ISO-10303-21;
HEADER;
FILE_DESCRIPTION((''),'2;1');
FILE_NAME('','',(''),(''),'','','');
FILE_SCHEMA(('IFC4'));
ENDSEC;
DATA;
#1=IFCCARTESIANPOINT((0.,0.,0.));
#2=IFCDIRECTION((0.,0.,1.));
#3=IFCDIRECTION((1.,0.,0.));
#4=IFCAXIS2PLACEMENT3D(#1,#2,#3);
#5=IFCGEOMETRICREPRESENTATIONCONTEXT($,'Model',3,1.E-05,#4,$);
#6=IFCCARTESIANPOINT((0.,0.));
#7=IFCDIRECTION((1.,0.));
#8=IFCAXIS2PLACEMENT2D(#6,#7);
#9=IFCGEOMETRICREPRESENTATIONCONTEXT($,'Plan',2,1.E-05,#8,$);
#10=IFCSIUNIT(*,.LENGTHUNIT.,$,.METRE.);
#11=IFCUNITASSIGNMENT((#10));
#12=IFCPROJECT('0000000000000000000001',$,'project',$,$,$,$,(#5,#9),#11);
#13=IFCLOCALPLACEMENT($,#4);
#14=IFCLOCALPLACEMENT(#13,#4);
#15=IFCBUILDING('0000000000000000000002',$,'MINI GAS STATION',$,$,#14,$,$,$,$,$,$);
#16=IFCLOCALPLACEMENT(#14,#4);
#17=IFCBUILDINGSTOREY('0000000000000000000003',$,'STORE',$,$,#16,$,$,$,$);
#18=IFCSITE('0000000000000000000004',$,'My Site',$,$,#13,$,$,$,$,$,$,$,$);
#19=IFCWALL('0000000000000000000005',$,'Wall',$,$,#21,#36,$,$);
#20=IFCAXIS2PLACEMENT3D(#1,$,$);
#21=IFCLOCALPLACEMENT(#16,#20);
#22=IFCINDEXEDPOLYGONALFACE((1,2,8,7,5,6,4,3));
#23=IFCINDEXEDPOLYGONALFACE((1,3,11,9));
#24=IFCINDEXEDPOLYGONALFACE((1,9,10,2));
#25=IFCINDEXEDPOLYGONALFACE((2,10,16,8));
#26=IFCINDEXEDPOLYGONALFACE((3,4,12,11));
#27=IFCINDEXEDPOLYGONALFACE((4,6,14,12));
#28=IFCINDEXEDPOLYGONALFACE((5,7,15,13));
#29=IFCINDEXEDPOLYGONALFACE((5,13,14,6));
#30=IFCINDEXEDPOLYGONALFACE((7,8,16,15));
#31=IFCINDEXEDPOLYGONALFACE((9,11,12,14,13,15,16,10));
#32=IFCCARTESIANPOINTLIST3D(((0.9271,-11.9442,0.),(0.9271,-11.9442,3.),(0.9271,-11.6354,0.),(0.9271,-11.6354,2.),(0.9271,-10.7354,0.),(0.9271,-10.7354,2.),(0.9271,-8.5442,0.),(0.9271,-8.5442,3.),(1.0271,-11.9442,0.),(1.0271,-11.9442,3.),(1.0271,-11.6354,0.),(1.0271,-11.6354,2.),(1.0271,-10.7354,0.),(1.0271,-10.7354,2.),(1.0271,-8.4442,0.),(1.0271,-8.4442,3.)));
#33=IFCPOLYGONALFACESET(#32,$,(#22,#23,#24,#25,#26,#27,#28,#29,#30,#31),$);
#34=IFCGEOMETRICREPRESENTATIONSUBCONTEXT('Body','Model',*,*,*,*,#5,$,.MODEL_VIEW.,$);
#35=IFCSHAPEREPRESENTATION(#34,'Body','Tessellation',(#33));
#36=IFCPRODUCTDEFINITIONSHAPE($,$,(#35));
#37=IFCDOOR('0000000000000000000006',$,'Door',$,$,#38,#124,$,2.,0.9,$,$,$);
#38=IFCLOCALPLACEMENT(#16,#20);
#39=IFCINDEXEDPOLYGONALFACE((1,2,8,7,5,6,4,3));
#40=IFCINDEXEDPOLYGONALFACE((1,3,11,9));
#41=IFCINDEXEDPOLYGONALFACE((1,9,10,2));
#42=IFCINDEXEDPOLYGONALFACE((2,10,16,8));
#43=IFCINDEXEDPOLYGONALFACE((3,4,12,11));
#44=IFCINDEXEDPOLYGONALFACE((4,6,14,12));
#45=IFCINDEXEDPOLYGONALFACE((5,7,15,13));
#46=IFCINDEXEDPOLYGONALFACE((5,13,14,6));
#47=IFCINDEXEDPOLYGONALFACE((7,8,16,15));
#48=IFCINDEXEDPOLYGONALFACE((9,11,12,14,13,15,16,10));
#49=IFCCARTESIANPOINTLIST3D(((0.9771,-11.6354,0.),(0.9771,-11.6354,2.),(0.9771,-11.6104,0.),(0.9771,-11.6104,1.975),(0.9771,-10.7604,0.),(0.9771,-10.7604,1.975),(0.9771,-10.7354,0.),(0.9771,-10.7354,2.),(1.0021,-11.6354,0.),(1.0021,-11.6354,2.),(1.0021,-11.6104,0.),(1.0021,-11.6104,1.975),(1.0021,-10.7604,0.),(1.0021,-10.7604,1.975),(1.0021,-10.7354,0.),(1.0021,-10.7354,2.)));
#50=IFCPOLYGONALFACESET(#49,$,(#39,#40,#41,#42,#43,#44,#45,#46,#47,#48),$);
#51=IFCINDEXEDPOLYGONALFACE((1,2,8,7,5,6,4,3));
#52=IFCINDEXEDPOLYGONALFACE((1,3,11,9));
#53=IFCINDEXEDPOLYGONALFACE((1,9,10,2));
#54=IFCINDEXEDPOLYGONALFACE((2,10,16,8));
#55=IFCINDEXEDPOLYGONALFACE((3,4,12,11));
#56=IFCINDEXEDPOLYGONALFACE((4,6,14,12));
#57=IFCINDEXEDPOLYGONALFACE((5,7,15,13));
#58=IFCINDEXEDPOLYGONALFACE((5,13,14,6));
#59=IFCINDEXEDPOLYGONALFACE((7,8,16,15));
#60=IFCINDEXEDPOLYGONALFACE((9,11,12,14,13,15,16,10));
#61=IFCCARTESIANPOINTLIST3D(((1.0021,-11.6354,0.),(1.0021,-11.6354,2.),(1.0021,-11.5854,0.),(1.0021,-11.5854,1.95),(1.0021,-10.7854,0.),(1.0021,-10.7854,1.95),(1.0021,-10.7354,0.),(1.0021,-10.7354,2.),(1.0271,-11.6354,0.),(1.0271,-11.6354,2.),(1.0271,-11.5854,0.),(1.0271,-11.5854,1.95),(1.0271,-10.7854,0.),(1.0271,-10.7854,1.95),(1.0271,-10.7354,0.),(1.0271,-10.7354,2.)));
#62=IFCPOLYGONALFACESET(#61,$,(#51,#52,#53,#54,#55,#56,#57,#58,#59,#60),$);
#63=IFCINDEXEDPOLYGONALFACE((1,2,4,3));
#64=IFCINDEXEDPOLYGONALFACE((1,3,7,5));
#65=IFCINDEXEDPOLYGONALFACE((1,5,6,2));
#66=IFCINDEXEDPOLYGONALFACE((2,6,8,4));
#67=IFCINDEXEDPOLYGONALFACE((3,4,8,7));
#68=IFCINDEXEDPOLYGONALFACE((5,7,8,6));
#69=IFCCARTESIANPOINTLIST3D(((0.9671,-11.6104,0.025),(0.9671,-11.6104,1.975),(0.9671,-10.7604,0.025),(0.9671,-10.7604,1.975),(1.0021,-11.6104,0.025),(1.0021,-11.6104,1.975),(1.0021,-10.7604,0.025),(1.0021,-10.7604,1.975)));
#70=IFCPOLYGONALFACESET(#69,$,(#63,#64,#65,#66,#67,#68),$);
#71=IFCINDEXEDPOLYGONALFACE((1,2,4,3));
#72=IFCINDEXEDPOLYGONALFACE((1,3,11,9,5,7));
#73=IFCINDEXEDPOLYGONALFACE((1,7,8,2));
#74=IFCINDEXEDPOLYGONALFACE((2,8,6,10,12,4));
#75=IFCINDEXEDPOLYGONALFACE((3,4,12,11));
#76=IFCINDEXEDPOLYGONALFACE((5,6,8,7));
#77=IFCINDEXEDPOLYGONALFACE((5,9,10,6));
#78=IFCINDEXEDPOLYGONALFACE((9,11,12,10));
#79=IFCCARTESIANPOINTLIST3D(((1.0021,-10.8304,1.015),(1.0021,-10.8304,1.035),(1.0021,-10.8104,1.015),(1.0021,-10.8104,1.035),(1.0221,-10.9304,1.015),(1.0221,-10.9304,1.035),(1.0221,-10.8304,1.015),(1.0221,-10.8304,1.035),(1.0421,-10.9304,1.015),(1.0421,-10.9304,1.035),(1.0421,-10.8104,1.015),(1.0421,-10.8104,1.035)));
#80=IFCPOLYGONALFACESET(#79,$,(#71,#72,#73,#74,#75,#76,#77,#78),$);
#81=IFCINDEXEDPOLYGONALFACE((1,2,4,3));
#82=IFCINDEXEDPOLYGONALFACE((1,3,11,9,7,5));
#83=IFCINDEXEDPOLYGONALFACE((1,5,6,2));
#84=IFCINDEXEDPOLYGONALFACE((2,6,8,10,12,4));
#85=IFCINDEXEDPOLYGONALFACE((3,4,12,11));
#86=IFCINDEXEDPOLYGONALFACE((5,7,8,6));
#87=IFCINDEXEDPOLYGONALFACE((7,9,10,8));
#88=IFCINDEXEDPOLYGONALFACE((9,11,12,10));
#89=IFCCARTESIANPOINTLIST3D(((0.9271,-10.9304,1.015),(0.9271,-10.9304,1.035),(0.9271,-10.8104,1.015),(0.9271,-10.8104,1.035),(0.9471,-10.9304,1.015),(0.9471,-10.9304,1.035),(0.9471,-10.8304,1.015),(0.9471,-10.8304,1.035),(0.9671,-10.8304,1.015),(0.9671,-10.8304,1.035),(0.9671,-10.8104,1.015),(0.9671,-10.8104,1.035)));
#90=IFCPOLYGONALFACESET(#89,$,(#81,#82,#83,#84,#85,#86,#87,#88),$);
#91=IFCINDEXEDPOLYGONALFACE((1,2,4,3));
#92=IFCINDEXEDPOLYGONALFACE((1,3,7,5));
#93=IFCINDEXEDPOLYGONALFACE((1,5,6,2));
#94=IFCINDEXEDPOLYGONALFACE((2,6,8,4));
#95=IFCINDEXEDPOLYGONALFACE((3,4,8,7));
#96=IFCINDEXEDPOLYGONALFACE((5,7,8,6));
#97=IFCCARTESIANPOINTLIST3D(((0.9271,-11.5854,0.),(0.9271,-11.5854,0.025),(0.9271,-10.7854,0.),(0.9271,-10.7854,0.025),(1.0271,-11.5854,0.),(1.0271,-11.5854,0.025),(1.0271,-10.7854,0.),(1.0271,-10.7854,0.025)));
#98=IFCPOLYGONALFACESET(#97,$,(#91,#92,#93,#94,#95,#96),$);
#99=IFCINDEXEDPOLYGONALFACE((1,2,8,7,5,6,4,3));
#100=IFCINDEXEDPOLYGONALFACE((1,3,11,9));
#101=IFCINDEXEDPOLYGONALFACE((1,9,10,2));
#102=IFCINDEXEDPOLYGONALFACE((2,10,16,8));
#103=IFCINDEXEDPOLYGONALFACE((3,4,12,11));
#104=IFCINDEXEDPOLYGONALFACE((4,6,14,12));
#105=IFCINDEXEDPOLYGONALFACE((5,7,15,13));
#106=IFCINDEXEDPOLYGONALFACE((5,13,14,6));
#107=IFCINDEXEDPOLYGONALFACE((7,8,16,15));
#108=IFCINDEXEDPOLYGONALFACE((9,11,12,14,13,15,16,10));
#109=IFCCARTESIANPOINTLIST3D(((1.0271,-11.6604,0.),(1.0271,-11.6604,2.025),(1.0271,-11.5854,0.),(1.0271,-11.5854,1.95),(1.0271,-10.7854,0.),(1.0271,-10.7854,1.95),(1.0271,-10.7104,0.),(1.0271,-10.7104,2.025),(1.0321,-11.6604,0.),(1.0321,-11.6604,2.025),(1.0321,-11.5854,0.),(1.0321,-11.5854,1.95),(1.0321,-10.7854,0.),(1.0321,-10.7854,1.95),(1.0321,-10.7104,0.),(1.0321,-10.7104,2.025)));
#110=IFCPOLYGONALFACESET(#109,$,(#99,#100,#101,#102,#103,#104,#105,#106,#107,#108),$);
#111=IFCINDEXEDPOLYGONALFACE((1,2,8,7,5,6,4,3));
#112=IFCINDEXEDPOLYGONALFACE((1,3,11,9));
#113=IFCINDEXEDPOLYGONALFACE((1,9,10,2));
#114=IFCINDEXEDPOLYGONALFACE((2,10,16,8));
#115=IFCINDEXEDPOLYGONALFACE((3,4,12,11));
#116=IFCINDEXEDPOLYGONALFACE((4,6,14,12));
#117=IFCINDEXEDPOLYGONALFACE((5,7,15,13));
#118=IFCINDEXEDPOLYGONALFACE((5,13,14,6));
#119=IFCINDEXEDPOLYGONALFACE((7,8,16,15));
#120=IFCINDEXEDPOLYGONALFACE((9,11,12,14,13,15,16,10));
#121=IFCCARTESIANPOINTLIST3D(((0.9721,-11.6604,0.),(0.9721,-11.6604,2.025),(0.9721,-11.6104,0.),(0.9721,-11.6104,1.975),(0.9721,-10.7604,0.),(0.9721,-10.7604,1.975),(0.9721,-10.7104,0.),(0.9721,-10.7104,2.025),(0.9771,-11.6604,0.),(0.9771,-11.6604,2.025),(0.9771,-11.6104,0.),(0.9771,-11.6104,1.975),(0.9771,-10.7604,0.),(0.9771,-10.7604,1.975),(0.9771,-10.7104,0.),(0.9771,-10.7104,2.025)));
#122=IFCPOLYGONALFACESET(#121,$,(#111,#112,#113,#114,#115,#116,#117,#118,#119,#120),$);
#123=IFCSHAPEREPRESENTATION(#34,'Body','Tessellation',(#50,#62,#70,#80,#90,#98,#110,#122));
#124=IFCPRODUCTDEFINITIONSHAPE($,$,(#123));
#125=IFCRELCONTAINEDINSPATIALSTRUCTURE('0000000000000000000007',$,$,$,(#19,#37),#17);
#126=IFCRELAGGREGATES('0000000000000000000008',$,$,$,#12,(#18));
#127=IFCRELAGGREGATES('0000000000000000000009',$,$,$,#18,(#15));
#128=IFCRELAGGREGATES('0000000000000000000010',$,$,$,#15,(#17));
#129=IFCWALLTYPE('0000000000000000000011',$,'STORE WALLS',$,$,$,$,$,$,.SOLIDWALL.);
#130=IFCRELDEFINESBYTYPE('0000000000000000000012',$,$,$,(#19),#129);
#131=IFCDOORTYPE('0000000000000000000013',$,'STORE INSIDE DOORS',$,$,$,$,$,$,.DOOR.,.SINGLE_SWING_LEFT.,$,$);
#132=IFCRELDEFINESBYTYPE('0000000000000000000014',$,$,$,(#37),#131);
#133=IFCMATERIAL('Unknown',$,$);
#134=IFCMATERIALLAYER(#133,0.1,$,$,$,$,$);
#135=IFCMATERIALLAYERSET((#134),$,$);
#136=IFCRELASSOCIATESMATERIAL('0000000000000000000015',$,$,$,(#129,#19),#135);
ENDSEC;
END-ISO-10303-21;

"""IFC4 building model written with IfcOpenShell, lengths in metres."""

from ifc_helpers import new_model, entity, si_unit, frame, origin_with_axes, origin_2d_with_axis, place, context, subcontext, project, spatial, line, indexed_curve, outline, extrude, shape, source, transform, mapped, material, layer, layer_set, layer_usage, type_object, type_shapes, element, fill, save


model = new_model("IFC4")

# Units and contexts
model_context = context("Model", 3, precision=1e-05, world=origin_with_axes())
plan_context = context("Plan", 2, precision=1e-05, world=origin_2d_with_axis())
body_context_1 = subcontext(model_context, "Body", "Model", "MODEL_VIEW")
body_context_2 = subcontext(plan_context, "Body", "Plan", "PLAN_VIEW")
ifc_project = project(units=[si_unit("LENGTHUNIT", "METRE")], contexts=[model_context, plan_context])

# Site, building, storey
site_placement = place(None, origin_with_axes())
site = spatial("IfcSite", under=ifc_project, at=site_placement, Name="My Site")
building_placement = place(site_placement, origin_with_axes())
building = spatial("IfcBuilding", under=site, at=building_placement, Name="MINI GAS STATION")
storey_placement = place(building_placement, origin_with_axes())
storey = spatial("IfcBuildingStorey", under=building, at=storey_placement, Name="STORE")

# Shared definitions
ifc_material = material(Name="Unknown")

# Shared definitions
ifc_layer_1 = layer(ifc_material, 0.1)
ifc_layer_set_1 = layer_set([ifc_layer_1])
wall_type_1 = type_object("IfcWallType", Name="STORE WALLS", PredefinedType="SOLIDWALL", material=ifc_layer_set_1)

# Wall, opening, door
ifc_layer_usage_1 = layer_usage(ifc_layer_set_1, "AXIS2", "POSITIVE", 0.0)
wall_1_placement = place(storey_placement, frame((1.0271, -11.9442, 0.0), z_axis=(0.0, 0.0, 1.0), x_axis=(0.0, 1.0, 0.0)))
wall_1 = element("IfcWall", 1, at=wall_1_placement, inside=storey, type_object=wall_type_1, material=ifc_layer_usage_1, Name="Wall", context=body_context_1, shape_type="SweptSolid", body=[
    extrude(outline(indexed_curve([(0.0, 0.0), (0.0, 0.1), (3.4, 0.1), (3.5, 0.0)], segments=[line(1, 2, 3, 4, 1)])), origin_with_axes(), (0.0, 0.0, 1.0), 3.0),
])
shared_shape_1 = source(origin_with_axes(), body_context_1, "Body", "SweptSolid", [
    extrude(outline(indexed_curve([(0.0, 0.0), (0.9, 0.0), (0.9, 2.0), (0.0, 2.0)], segments=[line(1, 2, 3, 4, 1)])), frame((0.0, -0.6, 0.0), z_axis=(0.0, -1.0, 0.0), x_axis=(1.0, 0.0, 0.0)), (0.0, 0.0, -1.0), 1.2),
])
opening_1_placement = place(wall_1_placement, frame((0.3088, 0.0, 0.0), z_axis=(0.0, 0.0, 1.0), x_axis=(1.0, 0.0, 0.0)))
opening_1 = element("IfcOpeningElement", 2, at=opening_1_placement, cuts=wall_1, PredefinedType="OPENING", context=body_context_1, shape_type="MappedRepresentation", body=[
    mapped(shared_shape_1, transform((0.0, 0.0, 0.0), x_axis=(1.0, 0.0, 0.0), y_axis=(0.0, 1.0, 0.0), z_axis=(0.0, 0.0, 1.0), scale=1.0)),
])
door_type = type_object("IfcDoorType", Name="STORE INSIDE DOORS", OperationType="SINGLE_SWING_LEFT", PredefinedType="DOOR")
shared_shape_2 = source(origin_with_axes(), body_context_1, "Body", "SweptSolid", [
    extrude(outline(indexed_curve([(0.0, 0.0), (0.0, 2.0), (0.9, 2.0), (0.9, 0.0), (0.875, 0.0), (0.875, 1.975), (0.025, 1.975), (0.025, 0.0)], segments=[line(1, 2, 3, 4, 5, 6, 7, 8, 1)])), frame((0.0, 0.025, 0.0), z_axis=(0.0, -1.0, 0.0), x_axis=(1.0, 0.0, 0.0)), (0.0, 0.0, -1.0), 0.025),
    extrude(outline(indexed_curve([(0.0, 0.0), (0.0, 2.0), (0.9, 2.0), (0.9, 0.0), (0.85, 0.0), (0.85, 1.95), (0.05, 1.95), (0.05, 0.0)], segments=[line(1, 2, 3, 4, 5, 6, 7, 8, 1)])), frame((0.0, 0.0, 0.0), z_axis=(0.0, -1.0, 0.0), x_axis=(1.0, 0.0, 0.0)), (0.0, 0.0, -1.0), 0.025),
    extrude(outline(indexed_curve([(0.0, 0.0), (0.85, 0.0), (0.85, 0.035), (0.0, 0.035)], segments=[line(1, 2, 3, 4, 1)])), frame((0.025, 0.025, 0.025), z_axis=(0.0, 0.0, 1.0), x_axis=(1.0, 0.0, 0.0)), (0.0, 0.0, 1.0), 1.95),
    extrude(outline(indexed_curve([(0.0, 0.0), (0.0, -0.04), (-0.12, -0.04), (-0.12, -0.02), (-0.02, -0.02), (-0.02, 0.0)], segments=[line(1, 2, 3, 4, 5, 6, 1)])), frame((0.825, 0.025, 1.015), z_axis=(0.0, 0.0, 1.0), x_axis=(1.0, 0.0, 0.0)), (0.0, 0.0, 1.0), 0.02),
    extrude(outline(indexed_curve([(0.0, 0.0), (0.0, 0.04), (-0.12, 0.04), (-0.12, 0.02), (-0.02, 0.02), (-0.02, 0.0)], segments=[line(1, 2, 3, 4, 5, 6, 1)])), frame((0.825, 0.06, 1.015), z_axis=(0.0, 0.0, 1.0), x_axis=(1.0, 0.0, 0.0)), (0.0, 0.0, 1.0), 0.02),
    extrude(outline(indexed_curve([(0.0, 0.0), (0.8, 0.0), (0.8, 0.1), (0.0, 0.1)], segments=[line(1, 2, 3, 4, 1)])), frame((0.05, 0.0, 0.0), z_axis=(0.0, 0.0, 1.0), x_axis=(1.0, 0.0, 0.0)), (0.0, 0.0, 1.0), 0.025),
    extrude(outline(indexed_curve([(0.0, 0.0), (0.0, 2.025), (0.95, 2.025), (0.95, 0.0), (0.875, 0.0), (0.875, 1.95), (0.075, 1.95), (0.075, 0.0)], segments=[line(1, 2, 3, 4, 5, 6, 7, 8, 1)])), frame((-0.025, -0.005, 0.0), z_axis=(0.0, -1.0, 0.0), x_axis=(1.0, 0.0, 0.0)), (0.0, 0.0, -1.0), 0.005),
    extrude(outline(indexed_curve([(0.0, 0.0), (0.0, 2.025), (0.95, 2.025), (0.95, 0.0), (0.9, 0.0), (0.9, 1.975), (0.05, 1.975), (0.05, 0.0)], segments=[line(1, 2, 3, 4, 5, 6, 7, 8, 1)])), frame((-0.025, 0.05, 0.0), z_axis=(0.0, -1.0, 0.0), x_axis=(1.0, 0.0, 0.0)), (0.0, 0.0, -1.0), 0.005),
])
shared_shape_3 = source(origin_with_axes(), body_context_2, "Body", "Curve2D", [
    entity("IfcIndexedPolyCurve", entity("IfcCartesianPointList2D", [[0.0, 0.0], [0.0, 0.05], [0.025, 0.05], [0.025, 0.025], [0.05, 0.025], [0.05, 0.0]]), [entity("IfcLineIndex", [1, 2, 3, 4, 5, 6, 1])]),
    entity("IfcIndexedPolyCurve", entity("IfcCartesianPointList2D", [[0.9, 0.0], [0.9, 0.05], [0.875, 0.05], [0.875, 0.025], [0.85, 0.025], [0.85, 0.0]]), [entity("IfcLineIndex", [1, 2, 3, 4, 5, 6, 1])]),
    entity("IfcTrimmedCurve", entity("IfcEllipse", entity("IfcAxis2Placement2D", entity("IfcCartesianPoint", [0.06, 0.05]), entity("IfcDirection", [1.0, 0.0])), 0.815, 0.85), [entity("IfcCartesianPoint", [0.875, 0.05])], [entity("IfcCartesianPoint", [0.06, 0.9])], True, "CARTESIAN"),
    entity("IfcIndexedPolyCurve", entity("IfcCartesianPointList2D", [[0.025, 0.05], [0.06, 0.05], [0.06, 0.9], [0.025, 0.9]]), [entity("IfcLineIndex", [1, 2, 3, 4, 1])]),
])
type_shapes(door_type, [shared_shape_2, shared_shape_3])
door_placement = place(opening_1_placement, frame((0.0, 0.0, 0.0), z_axis=(0.0, 0.0, 1.0), x_axis=(1.0, 0.0, 0.0)))
door = element("IfcDoor", 3, at=door_placement, inside=storey, type_object=door_type, Name="Door", OverallHeight=2.0, OverallWidth=0.9, shapes=[
    shape(body_context_1, "Body", "MappedRepresentation", [mapped(shared_shape_2, transform((0.0, 0.0, 0.0), x_axis=(1.0, 0.0, 0.0), y_axis=(0.0, 1.0, 0.0), z_axis=(0.0, 0.0, 1.0), scale=1.0))]),
    shape(body_context_2, "Body", "MappedRepresentation", [mapped(shared_shape_3, transform((0.0, 0.0, 0.0), x_axis=(1.0, 0.0, 0.0), y_axis=(0.0, 1.0, 0.0), z_axis=(0.0, 0.0, 1.0), scale=1.0))]),
])
fill(opening_1, door)

save(model, "model.ifc")
